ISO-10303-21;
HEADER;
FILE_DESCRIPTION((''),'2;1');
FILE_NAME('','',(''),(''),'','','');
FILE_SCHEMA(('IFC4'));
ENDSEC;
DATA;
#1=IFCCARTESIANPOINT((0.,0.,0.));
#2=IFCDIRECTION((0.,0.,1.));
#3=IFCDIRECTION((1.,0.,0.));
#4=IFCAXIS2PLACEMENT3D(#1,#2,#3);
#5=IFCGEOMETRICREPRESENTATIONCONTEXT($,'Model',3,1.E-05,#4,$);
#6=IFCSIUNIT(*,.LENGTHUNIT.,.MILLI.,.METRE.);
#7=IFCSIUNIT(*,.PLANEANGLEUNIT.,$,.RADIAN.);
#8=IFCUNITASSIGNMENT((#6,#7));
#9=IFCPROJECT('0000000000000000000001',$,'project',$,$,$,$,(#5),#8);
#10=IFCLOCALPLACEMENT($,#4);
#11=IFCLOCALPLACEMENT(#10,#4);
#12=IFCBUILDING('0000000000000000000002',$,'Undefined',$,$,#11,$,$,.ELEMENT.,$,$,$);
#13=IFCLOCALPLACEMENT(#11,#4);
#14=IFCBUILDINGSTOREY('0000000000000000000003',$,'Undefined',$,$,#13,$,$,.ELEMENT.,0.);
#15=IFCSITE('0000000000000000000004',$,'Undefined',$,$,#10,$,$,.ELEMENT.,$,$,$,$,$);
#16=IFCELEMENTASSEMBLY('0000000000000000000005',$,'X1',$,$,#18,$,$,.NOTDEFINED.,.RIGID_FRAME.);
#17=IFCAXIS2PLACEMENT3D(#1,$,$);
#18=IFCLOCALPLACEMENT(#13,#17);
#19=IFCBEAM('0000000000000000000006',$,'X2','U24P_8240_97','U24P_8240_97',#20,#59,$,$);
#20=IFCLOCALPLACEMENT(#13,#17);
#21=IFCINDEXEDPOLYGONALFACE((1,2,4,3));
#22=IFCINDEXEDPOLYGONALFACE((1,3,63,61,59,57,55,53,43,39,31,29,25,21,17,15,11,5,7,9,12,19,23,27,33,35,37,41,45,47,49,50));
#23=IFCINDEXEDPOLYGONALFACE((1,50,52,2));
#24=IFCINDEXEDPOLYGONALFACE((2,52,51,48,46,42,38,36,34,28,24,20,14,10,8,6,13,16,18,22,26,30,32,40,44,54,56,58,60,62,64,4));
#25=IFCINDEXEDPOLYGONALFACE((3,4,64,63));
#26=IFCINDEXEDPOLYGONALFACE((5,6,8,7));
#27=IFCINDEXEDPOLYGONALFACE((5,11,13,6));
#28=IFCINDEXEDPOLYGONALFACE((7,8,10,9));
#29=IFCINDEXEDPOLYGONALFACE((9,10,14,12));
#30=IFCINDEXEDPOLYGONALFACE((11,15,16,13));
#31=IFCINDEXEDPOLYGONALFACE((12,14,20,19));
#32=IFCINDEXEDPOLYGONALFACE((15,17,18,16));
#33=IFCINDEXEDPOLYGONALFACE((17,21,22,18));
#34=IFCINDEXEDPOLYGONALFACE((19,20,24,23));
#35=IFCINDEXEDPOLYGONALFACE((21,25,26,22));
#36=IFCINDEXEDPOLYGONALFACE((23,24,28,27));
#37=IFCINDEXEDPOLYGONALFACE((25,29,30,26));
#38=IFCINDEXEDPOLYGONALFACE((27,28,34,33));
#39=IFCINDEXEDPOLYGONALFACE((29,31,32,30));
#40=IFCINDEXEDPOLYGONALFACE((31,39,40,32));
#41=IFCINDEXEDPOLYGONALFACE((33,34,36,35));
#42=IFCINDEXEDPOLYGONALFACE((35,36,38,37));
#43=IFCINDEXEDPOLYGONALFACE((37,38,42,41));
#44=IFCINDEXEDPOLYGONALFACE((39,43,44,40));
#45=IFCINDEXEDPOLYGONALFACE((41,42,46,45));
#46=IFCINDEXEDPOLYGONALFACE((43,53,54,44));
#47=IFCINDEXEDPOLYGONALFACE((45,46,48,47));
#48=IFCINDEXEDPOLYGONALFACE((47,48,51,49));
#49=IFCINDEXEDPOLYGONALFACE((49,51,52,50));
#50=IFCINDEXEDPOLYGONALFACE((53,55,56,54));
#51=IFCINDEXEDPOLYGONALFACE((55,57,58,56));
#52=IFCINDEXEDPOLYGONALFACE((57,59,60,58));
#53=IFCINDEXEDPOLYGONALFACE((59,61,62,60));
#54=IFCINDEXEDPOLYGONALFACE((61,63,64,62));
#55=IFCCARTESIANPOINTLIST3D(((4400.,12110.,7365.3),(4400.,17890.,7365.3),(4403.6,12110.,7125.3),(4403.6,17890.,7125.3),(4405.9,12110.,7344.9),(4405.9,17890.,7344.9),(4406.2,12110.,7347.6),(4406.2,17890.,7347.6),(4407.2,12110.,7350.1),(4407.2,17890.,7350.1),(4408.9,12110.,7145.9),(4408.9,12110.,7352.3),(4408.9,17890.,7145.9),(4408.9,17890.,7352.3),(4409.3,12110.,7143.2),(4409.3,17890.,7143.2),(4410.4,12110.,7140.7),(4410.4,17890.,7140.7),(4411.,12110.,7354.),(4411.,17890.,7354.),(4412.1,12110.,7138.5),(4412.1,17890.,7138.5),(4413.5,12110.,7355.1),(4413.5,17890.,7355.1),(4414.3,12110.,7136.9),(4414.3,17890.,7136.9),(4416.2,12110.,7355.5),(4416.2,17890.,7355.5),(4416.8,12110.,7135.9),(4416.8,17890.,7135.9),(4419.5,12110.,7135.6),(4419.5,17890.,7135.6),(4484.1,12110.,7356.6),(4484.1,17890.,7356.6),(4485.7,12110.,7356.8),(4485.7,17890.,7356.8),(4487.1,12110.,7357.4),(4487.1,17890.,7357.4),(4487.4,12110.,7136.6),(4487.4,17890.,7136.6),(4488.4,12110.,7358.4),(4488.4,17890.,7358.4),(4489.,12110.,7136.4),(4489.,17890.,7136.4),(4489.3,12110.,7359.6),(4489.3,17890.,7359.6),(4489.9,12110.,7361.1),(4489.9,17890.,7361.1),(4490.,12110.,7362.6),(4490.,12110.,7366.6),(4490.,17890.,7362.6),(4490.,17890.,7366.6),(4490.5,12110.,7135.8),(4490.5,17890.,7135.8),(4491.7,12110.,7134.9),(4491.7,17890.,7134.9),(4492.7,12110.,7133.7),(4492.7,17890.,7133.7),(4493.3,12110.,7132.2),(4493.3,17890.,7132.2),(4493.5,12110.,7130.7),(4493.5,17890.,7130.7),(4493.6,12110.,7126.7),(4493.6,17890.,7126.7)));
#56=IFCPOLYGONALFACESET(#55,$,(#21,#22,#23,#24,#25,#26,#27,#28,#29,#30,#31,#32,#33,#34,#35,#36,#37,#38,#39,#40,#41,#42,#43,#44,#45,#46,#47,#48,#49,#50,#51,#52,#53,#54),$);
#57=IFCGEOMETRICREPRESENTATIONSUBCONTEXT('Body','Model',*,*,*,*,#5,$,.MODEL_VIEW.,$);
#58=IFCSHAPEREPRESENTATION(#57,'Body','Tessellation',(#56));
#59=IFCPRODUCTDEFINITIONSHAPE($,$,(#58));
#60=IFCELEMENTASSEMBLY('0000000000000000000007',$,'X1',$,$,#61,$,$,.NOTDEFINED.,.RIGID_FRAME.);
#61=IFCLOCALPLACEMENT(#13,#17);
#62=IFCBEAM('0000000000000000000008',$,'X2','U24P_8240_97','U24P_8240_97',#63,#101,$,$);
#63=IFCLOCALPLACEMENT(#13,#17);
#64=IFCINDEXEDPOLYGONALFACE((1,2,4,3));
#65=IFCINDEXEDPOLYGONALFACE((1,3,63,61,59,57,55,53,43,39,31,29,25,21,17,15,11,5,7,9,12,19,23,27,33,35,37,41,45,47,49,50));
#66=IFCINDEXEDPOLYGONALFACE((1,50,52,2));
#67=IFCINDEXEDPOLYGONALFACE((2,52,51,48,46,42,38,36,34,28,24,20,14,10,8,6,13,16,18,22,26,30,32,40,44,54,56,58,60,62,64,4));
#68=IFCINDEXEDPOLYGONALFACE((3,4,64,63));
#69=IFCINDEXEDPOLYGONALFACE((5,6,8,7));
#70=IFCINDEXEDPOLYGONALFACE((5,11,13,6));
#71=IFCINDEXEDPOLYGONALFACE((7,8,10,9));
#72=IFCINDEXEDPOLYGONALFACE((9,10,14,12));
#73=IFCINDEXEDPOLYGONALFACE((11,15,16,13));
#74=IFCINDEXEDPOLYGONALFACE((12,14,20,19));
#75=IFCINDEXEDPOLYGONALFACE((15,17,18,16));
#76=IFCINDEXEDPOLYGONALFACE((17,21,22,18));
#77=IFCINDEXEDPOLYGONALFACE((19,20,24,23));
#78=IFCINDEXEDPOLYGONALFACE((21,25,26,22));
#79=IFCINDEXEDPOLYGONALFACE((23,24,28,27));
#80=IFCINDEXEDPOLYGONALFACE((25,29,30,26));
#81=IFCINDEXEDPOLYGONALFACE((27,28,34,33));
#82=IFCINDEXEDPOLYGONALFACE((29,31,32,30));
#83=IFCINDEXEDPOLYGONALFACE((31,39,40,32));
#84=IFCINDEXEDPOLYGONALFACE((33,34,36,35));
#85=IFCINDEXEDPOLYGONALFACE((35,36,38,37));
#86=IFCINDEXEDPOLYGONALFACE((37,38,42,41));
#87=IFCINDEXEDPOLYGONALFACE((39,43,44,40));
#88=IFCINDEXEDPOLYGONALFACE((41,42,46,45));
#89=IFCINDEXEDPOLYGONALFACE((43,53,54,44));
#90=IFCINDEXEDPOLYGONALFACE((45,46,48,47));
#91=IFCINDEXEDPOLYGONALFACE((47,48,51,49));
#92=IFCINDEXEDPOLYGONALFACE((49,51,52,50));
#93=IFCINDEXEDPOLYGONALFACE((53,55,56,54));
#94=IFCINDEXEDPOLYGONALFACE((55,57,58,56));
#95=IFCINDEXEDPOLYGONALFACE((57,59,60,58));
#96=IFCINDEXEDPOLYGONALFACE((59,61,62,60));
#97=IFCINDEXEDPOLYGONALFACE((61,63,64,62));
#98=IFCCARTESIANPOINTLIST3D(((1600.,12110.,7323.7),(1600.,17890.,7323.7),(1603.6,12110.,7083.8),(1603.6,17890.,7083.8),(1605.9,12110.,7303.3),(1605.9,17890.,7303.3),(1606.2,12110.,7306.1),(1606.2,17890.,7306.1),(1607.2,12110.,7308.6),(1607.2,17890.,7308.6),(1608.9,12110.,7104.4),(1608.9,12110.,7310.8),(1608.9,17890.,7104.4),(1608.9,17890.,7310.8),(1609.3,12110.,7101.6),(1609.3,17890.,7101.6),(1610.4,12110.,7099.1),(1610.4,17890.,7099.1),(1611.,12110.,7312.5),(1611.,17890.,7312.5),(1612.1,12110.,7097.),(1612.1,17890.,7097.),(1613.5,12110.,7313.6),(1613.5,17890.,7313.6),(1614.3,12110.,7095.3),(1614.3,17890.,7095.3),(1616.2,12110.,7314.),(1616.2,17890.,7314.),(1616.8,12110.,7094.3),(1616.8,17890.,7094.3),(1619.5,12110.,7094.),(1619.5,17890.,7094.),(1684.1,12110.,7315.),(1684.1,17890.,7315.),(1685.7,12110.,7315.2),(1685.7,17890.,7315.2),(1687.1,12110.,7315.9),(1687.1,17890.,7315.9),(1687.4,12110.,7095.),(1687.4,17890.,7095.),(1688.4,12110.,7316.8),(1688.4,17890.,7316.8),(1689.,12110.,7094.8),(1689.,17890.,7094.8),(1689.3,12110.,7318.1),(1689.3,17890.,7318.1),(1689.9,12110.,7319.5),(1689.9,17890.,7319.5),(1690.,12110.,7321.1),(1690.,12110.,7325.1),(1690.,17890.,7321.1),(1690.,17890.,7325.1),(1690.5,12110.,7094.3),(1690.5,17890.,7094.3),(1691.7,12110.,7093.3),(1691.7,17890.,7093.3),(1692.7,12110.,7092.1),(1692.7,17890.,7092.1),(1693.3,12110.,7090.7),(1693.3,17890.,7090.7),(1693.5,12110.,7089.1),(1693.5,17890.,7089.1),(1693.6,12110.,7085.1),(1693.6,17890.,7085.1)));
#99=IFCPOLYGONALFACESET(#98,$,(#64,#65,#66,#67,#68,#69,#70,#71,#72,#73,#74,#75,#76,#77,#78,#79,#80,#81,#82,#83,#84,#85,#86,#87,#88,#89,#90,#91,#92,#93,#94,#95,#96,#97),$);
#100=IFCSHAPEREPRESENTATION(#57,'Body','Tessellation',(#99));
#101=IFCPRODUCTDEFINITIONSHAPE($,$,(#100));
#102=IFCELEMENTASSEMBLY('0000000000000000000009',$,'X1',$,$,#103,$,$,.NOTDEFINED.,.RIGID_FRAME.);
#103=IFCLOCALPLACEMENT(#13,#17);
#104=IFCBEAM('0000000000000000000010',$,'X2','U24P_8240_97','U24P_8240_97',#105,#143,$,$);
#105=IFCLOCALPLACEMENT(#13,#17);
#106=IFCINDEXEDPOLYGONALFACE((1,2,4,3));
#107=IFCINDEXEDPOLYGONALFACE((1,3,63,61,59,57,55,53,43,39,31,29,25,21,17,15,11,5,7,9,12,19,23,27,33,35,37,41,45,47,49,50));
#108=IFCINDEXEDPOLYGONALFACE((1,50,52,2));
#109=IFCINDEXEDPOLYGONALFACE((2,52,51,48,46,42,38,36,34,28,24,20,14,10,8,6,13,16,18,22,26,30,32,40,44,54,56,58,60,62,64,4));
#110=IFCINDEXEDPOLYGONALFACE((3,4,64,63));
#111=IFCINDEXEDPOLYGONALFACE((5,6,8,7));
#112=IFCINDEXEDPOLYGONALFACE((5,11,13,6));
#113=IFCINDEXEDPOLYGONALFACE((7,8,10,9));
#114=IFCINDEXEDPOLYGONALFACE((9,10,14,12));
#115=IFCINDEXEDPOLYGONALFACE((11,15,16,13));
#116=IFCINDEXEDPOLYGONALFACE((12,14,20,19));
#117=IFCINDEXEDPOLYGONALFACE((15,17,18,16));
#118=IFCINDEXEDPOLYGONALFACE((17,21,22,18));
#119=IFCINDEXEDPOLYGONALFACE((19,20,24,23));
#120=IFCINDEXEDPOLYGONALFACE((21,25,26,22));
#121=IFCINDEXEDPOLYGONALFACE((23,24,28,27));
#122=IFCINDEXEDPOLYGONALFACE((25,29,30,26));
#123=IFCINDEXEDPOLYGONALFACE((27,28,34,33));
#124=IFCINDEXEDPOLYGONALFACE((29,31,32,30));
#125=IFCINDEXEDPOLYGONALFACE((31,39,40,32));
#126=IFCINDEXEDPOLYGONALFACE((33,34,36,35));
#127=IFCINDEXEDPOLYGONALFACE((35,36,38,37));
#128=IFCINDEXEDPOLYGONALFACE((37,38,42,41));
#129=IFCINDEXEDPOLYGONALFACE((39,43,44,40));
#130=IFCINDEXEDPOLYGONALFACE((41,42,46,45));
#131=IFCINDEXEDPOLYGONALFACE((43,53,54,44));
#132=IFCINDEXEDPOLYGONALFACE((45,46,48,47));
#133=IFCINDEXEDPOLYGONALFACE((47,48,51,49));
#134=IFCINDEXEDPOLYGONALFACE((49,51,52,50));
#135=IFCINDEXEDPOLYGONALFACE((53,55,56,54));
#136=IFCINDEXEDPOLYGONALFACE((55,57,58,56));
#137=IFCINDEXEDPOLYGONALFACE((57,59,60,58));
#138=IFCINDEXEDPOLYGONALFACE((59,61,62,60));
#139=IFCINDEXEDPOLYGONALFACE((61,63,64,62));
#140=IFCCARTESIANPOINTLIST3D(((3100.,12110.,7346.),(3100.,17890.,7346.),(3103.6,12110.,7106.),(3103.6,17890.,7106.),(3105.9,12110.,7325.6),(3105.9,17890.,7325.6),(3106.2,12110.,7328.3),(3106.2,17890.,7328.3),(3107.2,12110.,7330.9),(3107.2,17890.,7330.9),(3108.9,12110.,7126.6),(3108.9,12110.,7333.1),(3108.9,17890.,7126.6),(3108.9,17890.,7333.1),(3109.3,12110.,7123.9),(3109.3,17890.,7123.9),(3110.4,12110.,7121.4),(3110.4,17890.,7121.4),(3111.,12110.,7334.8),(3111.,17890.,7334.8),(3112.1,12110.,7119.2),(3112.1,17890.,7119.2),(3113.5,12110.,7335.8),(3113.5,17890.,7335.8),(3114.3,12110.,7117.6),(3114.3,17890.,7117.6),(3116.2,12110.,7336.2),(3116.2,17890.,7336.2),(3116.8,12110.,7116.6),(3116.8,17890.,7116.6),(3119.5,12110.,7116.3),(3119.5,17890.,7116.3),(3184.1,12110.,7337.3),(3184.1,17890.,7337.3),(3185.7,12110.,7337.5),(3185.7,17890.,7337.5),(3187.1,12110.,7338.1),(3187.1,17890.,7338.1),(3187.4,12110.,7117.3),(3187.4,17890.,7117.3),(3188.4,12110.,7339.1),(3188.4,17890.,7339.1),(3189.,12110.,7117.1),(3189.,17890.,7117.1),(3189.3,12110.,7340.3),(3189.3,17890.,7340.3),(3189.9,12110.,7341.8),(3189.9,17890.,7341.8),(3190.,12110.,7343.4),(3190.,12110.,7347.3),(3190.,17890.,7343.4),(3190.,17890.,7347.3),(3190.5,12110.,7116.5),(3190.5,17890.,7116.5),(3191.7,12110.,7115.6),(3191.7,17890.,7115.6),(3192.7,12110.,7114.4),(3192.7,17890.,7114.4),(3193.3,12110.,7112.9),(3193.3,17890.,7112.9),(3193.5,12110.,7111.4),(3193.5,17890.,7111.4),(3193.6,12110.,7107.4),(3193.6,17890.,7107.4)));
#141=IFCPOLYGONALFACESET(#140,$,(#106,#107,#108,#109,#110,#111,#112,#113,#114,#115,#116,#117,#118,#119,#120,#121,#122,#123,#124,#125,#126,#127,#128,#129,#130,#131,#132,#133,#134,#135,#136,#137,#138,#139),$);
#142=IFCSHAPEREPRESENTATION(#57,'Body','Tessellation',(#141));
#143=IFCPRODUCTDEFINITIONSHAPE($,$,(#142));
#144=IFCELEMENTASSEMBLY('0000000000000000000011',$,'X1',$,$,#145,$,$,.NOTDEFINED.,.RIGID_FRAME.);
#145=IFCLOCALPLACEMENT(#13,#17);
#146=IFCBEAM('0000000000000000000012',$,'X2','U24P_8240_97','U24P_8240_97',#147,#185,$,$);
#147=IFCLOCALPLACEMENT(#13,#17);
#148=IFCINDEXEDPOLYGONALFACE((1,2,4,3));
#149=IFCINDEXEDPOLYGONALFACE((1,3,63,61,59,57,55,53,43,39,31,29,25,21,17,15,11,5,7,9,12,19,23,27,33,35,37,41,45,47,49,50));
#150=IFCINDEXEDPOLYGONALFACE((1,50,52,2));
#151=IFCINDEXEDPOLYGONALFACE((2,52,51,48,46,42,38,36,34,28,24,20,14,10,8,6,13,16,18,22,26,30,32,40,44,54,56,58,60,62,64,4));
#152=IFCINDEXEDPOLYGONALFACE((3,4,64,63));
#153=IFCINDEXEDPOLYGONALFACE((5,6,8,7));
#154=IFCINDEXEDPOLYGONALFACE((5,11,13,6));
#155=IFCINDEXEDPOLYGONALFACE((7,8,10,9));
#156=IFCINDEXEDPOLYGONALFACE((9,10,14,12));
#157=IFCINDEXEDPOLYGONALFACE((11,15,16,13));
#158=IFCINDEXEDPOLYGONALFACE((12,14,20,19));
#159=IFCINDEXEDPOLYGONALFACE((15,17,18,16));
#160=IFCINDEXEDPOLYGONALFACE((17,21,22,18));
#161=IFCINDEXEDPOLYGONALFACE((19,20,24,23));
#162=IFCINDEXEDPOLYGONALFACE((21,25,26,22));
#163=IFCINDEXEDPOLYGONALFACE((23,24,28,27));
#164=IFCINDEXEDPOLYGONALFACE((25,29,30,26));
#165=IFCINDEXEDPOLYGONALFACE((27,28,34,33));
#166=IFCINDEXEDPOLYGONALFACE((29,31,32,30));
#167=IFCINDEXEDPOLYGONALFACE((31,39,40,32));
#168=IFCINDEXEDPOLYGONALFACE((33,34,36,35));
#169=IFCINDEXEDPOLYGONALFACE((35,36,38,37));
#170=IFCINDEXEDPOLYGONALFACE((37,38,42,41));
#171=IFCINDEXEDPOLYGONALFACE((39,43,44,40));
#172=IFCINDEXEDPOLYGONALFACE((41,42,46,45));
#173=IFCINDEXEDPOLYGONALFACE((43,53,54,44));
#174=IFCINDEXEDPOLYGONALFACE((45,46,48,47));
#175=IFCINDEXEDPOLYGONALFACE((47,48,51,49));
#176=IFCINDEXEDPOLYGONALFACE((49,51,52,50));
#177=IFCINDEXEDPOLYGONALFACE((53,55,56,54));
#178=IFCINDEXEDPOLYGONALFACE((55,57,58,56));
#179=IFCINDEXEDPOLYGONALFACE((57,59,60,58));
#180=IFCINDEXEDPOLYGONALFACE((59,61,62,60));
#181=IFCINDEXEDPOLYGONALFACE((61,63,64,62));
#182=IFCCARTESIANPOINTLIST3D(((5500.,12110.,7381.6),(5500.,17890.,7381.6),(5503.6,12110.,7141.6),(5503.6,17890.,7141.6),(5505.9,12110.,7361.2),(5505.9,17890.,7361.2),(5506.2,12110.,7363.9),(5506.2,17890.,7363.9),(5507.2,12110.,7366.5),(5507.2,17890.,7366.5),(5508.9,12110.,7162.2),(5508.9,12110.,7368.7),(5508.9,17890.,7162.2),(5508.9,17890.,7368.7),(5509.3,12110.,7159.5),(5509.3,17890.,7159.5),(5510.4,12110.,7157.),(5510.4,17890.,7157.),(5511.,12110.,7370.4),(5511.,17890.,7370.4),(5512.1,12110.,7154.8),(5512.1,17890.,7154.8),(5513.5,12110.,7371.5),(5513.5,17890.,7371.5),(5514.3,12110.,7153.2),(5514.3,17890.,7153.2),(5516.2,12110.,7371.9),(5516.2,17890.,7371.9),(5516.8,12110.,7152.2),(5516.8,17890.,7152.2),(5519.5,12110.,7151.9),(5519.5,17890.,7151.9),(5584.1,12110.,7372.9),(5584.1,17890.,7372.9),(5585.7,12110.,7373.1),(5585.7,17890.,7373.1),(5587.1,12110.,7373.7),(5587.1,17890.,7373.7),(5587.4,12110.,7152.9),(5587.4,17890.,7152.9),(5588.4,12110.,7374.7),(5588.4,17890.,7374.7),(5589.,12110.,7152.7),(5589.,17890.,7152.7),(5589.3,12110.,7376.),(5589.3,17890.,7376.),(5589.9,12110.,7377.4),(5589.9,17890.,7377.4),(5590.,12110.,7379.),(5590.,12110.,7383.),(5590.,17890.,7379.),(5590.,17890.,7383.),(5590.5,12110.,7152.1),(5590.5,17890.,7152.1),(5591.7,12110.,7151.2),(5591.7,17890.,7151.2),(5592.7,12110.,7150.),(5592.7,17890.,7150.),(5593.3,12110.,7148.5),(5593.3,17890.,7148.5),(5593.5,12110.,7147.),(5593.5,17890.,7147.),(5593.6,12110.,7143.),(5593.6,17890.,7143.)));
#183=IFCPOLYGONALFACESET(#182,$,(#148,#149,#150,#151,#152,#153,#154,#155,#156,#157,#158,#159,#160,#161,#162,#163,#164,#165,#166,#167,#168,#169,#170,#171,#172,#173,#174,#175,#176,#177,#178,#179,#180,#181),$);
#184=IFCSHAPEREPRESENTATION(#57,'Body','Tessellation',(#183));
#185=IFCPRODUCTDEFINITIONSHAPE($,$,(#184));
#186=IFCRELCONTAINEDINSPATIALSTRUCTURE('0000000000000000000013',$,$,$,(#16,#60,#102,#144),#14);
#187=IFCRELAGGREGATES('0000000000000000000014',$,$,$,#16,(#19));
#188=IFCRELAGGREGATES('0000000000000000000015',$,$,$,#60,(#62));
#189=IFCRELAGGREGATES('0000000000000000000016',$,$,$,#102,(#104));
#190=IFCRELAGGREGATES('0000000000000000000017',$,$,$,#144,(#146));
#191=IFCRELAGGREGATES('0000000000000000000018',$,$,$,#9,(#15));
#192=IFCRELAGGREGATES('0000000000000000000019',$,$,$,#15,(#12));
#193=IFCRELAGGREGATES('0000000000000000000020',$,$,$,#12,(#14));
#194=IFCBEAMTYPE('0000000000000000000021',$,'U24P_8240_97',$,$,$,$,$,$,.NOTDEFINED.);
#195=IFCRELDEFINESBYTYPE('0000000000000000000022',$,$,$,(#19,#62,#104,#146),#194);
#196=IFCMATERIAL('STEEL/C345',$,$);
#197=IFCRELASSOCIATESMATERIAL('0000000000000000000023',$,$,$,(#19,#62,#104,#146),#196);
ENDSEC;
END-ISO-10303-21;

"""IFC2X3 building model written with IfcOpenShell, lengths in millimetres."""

from ifc_helpers import new_model, si_unit, frame, origin_with_axes, origin_2d_with_axis, place, context, subcontext, project, spatial, u_section, extrude, material, type_object, element, aggregate, save


model = new_model("IFC2X3")

# Units and contexts
model_context = context("Model", 3, precision=1e-05, world=origin_with_axes())
body_context = subcontext(model_context, "Body", "Model", "MODEL_VIEW")
ifc_project = project(units=[si_unit("LENGTHUNIT", "METRE", prefix="MILLI"), si_unit("PLANEANGLEUNIT", "RADIAN")], contexts=[model_context])

# Site, building, storey
site_placement = place(None, origin_with_axes())
site = spatial("IfcSite", under=ifc_project, at=site_placement, Name="Undefined", CompositionType="ELEMENT")
building_placement = place(site_placement, origin_with_axes())
building = spatial("IfcBuilding", under=site, at=building_placement, Name="Undefined", CompositionType="ELEMENT")
storey_placement = place(building_placement, origin_with_axes())
storey = spatial("IfcBuildingStorey", under=building, at=storey_placement, Name="Undefined", CompositionType="ELEMENT", Elevation=0.0)

# Element assemblies, beams
assembly_1_placement = place(storey_placement, origin_with_axes())
assembly_1 = element("IfcElementAssembly", 1, at=assembly_1_placement, inside=storey, Name="X1", AssemblyPlace="NOTDEFINED", PredefinedType="RIGID_FRAME")
ifc_material_1 = material(Name="STEEL/C345")
beam_type_1 = type_object("IfcBeamType", Name="U24P_8240_97", PredefinedType="NOTDEFINED")
beam_1_placement = place(assembly_1_placement, frame((4446.8, 17890.0, 7246.0), z_axis=(0.014998, 0.0, -0.999888), x_axis=(0.0, -1.0, 0.0)))
beam_1 = element("IfcBeam", 2, at=beam_1_placement, type_object=beam_type_1, material=ifc_material_1, Name="X2", Description="U24P_8240_97", ObjectType="U24P_8240_97", context=body_context, shape_type="SweptSolid", body=[
    extrude(u_section(Depth=240.0, FlangeWidth=90.0, WebThickness=5.6, FlangeThickness=10.0, FilletRadius=10.5, EdgeRadius=6.0, at=origin_2d_with_axis()), frame((5780.0, 0.0, 0.0), z_axis=(-1.0, 0.0, 0.0), x_axis=(0.0, -1.0, 0.0)), (0.0, 0.0, 1.0), 5780.0),
])
aggregate(assembly_1, [beam_1])
assembly_2_placement = place(storey_placement, origin_with_axes())
assembly_2 = element("IfcElementAssembly", 3, at=assembly_2_placement, inside=storey, Name="X1", AssemblyPlace="NOTDEFINED", PredefinedType="RIGID_FRAME")
beam_2_placement = place(assembly_2_placement, frame((1646.8, 17890.0, 7204.4), z_axis=(0.014998, 0.0, -0.999888), x_axis=(0.0, -1.0, 0.0)))
beam_2 = element("IfcBeam", 4, at=beam_2_placement, type_object=beam_type_1, material=ifc_material_1, Name="X2", Description="U24P_8240_97", ObjectType="U24P_8240_97", context=body_context, shape_type="SweptSolid", body=[
    extrude(u_section(Depth=240.0, FlangeWidth=90.0, WebThickness=5.6, FlangeThickness=10.0, FilletRadius=10.5, EdgeRadius=6.0, at=origin_2d_with_axis()), frame((5780.0, 0.0, 0.0), z_axis=(-1.0, 0.0, 0.0), x_axis=(0.0, -1.0, 0.0)), (0.0, 0.0, 1.0), 5780.0),
])
aggregate(assembly_2, [beam_2])
assembly_3_placement = place(storey_placement, origin_with_axes())
assembly_3 = element("IfcElementAssembly", 5, at=assembly_3_placement, inside=storey, Name="X1", AssemblyPlace="NOTDEFINED", PredefinedType="RIGID_FRAME")
beam_3_placement = place(assembly_3_placement, frame((3146.8, 17890.0, 7226.7), z_axis=(0.014998, 0.0, -0.999888), x_axis=(0.0, -1.0, 0.0)))
beam_3 = element("IfcBeam", 6, at=beam_3_placement, type_object=beam_type_1, material=ifc_material_1, Name="X2", Description="U24P_8240_97", ObjectType="U24P_8240_97", context=body_context, shape_type="SweptSolid", body=[
    extrude(u_section(Depth=240.0, FlangeWidth=90.0, WebThickness=5.6, FlangeThickness=10.0, FilletRadius=10.5, EdgeRadius=6.0, at=origin_2d_with_axis()), frame((5780.0, 0.0, 0.0), z_axis=(-1.0, 0.0, 0.0), x_axis=(0.0, -1.0, 0.0)), (0.0, 0.0, 1.0), 5780.0),
])
aggregate(assembly_3, [beam_3])
assembly_4_placement = place(storey_placement, origin_with_axes())
assembly_4 = element("IfcElementAssembly", 7, at=assembly_4_placement, inside=storey, Name="X1", AssemblyPlace="NOTDEFINED", PredefinedType="RIGID_FRAME")
beam_4_placement = place(assembly_4_placement, frame((5546.8, 17890.0, 7262.3), z_axis=(0.014998, 0.0, -0.999888), x_axis=(0.0, -1.0, 0.0)))
beam_4 = element("IfcBeam", 8, at=beam_4_placement, type_object=beam_type_1, material=ifc_material_1, Name="X2", Description="U24P_8240_97", ObjectType="U24P_8240_97", context=body_context, shape_type="SweptSolid", body=[
    extrude(u_section(Depth=240.0, FlangeWidth=90.0, WebThickness=5.6, FlangeThickness=10.0, FilletRadius=10.5, EdgeRadius=6.0, at=origin_2d_with_axis()), frame((5780.0, 0.0, 0.0), z_axis=(-1.0, 0.0, 0.0), x_axis=(0.0, -1.0, 0.0)), (0.0, 0.0, 1.0), 5780.0),
])
aggregate(assembly_4, [beam_4])

save(model, "model.ifc")
